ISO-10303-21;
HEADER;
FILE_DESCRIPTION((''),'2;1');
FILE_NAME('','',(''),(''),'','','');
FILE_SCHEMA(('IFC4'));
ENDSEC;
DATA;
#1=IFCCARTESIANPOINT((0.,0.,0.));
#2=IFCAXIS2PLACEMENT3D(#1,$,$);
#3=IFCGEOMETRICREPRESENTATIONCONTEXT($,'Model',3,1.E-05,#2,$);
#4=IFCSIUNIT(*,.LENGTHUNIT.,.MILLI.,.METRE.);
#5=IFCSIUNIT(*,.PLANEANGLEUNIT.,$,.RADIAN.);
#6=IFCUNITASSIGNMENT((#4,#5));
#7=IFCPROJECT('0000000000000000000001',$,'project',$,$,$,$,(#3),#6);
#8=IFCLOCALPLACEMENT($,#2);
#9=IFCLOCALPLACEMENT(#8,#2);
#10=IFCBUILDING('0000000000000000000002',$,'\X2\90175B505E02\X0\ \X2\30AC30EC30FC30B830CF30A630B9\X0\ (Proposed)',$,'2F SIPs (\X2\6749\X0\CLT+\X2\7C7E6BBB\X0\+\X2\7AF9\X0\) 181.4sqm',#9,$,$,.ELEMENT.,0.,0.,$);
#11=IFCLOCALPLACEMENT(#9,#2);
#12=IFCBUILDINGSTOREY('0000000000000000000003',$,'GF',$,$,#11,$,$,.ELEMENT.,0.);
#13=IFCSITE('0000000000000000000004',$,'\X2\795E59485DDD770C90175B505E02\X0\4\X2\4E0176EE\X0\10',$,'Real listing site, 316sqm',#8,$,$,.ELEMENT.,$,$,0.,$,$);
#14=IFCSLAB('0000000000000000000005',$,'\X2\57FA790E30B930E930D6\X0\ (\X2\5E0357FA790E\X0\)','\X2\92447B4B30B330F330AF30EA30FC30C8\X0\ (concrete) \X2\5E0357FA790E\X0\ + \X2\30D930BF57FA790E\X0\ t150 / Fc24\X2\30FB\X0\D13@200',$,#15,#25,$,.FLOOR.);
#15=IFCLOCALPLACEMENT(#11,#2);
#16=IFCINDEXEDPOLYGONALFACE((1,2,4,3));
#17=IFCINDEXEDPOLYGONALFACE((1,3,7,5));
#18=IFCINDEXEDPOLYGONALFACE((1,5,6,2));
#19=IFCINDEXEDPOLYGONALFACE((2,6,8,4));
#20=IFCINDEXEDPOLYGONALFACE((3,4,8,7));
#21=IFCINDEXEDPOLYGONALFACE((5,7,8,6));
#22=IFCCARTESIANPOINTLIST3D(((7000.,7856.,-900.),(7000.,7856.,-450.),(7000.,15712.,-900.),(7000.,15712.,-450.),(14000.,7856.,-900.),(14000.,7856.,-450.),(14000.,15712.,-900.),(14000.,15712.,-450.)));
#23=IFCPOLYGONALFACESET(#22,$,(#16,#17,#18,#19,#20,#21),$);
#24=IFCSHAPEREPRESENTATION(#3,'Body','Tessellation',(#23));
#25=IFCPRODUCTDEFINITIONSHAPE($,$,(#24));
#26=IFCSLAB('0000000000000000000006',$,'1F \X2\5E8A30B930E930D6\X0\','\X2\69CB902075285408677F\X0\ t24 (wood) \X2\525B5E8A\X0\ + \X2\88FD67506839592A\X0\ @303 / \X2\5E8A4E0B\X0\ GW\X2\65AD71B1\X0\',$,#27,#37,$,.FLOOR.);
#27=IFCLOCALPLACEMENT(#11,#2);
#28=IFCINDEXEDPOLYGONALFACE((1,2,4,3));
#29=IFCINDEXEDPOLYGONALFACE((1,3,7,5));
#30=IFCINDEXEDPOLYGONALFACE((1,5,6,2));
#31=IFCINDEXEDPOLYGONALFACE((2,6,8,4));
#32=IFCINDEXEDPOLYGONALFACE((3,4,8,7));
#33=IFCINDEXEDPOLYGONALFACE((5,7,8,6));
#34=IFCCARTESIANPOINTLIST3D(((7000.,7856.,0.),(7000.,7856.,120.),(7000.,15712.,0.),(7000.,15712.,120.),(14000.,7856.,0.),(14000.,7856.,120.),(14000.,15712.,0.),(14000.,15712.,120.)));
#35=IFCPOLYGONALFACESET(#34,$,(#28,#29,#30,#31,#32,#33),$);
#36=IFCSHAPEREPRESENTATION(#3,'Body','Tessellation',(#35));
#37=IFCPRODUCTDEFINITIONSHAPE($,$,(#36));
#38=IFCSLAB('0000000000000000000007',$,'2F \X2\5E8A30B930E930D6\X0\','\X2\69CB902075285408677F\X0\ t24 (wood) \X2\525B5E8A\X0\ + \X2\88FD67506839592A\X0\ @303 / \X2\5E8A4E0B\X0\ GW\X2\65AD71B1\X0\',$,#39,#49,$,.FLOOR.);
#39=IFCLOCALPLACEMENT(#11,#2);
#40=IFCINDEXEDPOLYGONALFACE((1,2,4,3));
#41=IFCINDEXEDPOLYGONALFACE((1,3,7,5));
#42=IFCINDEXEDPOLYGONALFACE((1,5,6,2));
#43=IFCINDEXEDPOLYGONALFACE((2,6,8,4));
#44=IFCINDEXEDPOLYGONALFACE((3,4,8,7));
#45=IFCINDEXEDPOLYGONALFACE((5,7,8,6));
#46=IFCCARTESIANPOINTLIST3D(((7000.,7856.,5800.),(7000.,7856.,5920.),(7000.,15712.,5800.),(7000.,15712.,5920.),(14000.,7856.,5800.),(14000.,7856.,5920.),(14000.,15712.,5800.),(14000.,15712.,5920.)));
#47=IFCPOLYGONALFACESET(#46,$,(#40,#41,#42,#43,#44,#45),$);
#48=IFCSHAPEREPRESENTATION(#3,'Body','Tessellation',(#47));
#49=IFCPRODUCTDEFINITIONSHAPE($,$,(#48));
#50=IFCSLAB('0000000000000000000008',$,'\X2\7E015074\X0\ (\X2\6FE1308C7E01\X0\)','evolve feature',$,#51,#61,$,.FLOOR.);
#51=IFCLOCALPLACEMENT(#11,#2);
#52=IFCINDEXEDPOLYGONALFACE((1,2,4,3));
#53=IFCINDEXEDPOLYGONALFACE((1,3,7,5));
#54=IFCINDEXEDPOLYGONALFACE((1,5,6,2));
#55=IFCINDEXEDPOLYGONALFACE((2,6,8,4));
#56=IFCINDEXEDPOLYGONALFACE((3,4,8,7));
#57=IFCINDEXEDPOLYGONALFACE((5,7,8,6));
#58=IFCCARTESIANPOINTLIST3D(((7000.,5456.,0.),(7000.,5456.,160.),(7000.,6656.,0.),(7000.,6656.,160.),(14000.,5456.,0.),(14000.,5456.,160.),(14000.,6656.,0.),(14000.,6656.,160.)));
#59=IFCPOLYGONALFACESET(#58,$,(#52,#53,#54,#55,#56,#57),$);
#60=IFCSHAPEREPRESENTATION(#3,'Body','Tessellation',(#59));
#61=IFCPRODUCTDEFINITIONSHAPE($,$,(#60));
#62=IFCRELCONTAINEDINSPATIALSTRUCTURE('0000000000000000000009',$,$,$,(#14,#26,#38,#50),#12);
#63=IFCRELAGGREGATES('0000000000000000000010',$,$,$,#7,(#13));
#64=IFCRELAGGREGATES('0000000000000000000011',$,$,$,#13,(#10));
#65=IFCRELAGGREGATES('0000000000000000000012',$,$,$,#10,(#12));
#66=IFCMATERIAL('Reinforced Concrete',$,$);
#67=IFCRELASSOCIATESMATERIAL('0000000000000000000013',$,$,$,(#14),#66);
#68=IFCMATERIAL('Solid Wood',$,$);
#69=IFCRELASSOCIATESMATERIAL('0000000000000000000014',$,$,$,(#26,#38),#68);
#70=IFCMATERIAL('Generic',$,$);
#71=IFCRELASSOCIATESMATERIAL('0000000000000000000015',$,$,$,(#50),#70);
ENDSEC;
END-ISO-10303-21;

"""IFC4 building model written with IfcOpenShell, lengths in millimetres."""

from ifc_helpers import new_model, si_unit, frame, frame_2d, origin, place, context, project, spatial, rectangle, extrude, material, element, save


model = new_model("IFC4")

# Units and contexts
model_context = context("Model", 3, precision=1e-05, world=origin())
ifc_project = project(units=[si_unit("LENGTHUNIT", "METRE", prefix="MILLI"), si_unit("PLANEANGLEUNIT", "RADIAN")], contexts=[model_context])

# Site, building, storey
site_placement = place(None, origin())
site = spatial("IfcSite", under=ifc_project, at=site_placement, Name="神奈川県逗子市4丁目10", ObjectType="Real listing site, 316sqm", CompositionType="ELEMENT", RefElevation=0.0)
building_placement = place(site_placement, origin())
building = spatial("IfcBuilding", under=site, at=building_placement, Name="逗子市 ガレージハウス (Proposed)", ObjectType="2F SIPs (杉CLT+籾殻+竹) 181.4sqm", CompositionType="ELEMENT", ElevationOfRefHeight=0.0, ElevationOfTerrain=0.0)
storey_placement = place(building_placement, origin())
storey = spatial("IfcBuildingStorey", under=building, at=storey_placement, Name="GF", CompositionType="ELEMENT", Elevation=0.0)

# Slabs
ifc_material_1 = material(Name="Reinforced Concrete")
slab_1_placement = place(storey_placement, frame((3500.0, 3928.0, -450.0)))
element("IfcSlab", 1, at=slab_1_placement, inside=storey, material=ifc_material_1, Name="基礎スラブ (布基礎)", Description="鉄筋コンクリート (concrete) 布基礎 + ベタ基礎 t150 / Fc24・D13@200", PredefinedType="FLOOR", context=model_context, shape_type="SweptSolid", body=[
    extrude(rectangle(XDim=7000.0, YDim=7856.0, at=frame_2d((3500.0, 3928.0))), frame((3500.0, 3928.0, -450.0)), (0.0, 0.0, 1.0), 450.0),
])
ifc_material_2 = material(Name="Solid Wood")
slab_2_placement = place(storey_placement, frame((3500.0, 3928.0, 0.0)))
element("IfcSlab", 2, at=slab_2_placement, inside=storey, material=ifc_material_2, Name="1F 床スラブ", Description="構造用合板 t24 (wood) 剛床 + 製材根太 @303 / 床下 GW断熱", PredefinedType="FLOOR", context=model_context, shape_type="SweptSolid", body=[
    extrude(rectangle(XDim=7000.0, YDim=7856.0, at=frame_2d((3500.0, 3928.0))), frame((3500.0, 3928.0, 0.0)), (0.0, 0.0, 1.0), 120.0),
])
slab_3_placement = place(storey_placement, frame((3500.0, 3928.0, 2900.0)))
element("IfcSlab", 3, at=slab_3_placement, inside=storey, material=ifc_material_2, Name="2F 床スラブ", Description="構造用合板 t24 (wood) 剛床 + 製材根太 @303 / 床下 GW断熱", PredefinedType="FLOOR", context=model_context, shape_type="SweptSolid", body=[
    extrude(rectangle(XDim=7000.0, YDim=7856.0, at=frame_2d((3500.0, 3928.0))), frame((3500.0, 3928.0, 2900.0)), (0.0, 0.0, 1.0), 120.0),
])
ifc_material_3 = material(Name="Generic")
slab_4_placement = place(storey_placement, frame((3500.0, 2728.0, 0.0)))
element("IfcSlab", 4, at=slab_4_placement, inside=storey, material=ifc_material_3, Name="縁側 (濡れ縁)", Description="evolve feature", PredefinedType="FLOOR", context=model_context, shape_type="SweptSolid", body=[
    extrude(rectangle(XDim=7000.0, YDim=1200.0, at=frame_2d((3500.0, 600.0))), frame((3500.0, 2728.0, 0.0)), (0.0, 0.0, 1.0), 160.0),
])

save(model, "model.ifc")
